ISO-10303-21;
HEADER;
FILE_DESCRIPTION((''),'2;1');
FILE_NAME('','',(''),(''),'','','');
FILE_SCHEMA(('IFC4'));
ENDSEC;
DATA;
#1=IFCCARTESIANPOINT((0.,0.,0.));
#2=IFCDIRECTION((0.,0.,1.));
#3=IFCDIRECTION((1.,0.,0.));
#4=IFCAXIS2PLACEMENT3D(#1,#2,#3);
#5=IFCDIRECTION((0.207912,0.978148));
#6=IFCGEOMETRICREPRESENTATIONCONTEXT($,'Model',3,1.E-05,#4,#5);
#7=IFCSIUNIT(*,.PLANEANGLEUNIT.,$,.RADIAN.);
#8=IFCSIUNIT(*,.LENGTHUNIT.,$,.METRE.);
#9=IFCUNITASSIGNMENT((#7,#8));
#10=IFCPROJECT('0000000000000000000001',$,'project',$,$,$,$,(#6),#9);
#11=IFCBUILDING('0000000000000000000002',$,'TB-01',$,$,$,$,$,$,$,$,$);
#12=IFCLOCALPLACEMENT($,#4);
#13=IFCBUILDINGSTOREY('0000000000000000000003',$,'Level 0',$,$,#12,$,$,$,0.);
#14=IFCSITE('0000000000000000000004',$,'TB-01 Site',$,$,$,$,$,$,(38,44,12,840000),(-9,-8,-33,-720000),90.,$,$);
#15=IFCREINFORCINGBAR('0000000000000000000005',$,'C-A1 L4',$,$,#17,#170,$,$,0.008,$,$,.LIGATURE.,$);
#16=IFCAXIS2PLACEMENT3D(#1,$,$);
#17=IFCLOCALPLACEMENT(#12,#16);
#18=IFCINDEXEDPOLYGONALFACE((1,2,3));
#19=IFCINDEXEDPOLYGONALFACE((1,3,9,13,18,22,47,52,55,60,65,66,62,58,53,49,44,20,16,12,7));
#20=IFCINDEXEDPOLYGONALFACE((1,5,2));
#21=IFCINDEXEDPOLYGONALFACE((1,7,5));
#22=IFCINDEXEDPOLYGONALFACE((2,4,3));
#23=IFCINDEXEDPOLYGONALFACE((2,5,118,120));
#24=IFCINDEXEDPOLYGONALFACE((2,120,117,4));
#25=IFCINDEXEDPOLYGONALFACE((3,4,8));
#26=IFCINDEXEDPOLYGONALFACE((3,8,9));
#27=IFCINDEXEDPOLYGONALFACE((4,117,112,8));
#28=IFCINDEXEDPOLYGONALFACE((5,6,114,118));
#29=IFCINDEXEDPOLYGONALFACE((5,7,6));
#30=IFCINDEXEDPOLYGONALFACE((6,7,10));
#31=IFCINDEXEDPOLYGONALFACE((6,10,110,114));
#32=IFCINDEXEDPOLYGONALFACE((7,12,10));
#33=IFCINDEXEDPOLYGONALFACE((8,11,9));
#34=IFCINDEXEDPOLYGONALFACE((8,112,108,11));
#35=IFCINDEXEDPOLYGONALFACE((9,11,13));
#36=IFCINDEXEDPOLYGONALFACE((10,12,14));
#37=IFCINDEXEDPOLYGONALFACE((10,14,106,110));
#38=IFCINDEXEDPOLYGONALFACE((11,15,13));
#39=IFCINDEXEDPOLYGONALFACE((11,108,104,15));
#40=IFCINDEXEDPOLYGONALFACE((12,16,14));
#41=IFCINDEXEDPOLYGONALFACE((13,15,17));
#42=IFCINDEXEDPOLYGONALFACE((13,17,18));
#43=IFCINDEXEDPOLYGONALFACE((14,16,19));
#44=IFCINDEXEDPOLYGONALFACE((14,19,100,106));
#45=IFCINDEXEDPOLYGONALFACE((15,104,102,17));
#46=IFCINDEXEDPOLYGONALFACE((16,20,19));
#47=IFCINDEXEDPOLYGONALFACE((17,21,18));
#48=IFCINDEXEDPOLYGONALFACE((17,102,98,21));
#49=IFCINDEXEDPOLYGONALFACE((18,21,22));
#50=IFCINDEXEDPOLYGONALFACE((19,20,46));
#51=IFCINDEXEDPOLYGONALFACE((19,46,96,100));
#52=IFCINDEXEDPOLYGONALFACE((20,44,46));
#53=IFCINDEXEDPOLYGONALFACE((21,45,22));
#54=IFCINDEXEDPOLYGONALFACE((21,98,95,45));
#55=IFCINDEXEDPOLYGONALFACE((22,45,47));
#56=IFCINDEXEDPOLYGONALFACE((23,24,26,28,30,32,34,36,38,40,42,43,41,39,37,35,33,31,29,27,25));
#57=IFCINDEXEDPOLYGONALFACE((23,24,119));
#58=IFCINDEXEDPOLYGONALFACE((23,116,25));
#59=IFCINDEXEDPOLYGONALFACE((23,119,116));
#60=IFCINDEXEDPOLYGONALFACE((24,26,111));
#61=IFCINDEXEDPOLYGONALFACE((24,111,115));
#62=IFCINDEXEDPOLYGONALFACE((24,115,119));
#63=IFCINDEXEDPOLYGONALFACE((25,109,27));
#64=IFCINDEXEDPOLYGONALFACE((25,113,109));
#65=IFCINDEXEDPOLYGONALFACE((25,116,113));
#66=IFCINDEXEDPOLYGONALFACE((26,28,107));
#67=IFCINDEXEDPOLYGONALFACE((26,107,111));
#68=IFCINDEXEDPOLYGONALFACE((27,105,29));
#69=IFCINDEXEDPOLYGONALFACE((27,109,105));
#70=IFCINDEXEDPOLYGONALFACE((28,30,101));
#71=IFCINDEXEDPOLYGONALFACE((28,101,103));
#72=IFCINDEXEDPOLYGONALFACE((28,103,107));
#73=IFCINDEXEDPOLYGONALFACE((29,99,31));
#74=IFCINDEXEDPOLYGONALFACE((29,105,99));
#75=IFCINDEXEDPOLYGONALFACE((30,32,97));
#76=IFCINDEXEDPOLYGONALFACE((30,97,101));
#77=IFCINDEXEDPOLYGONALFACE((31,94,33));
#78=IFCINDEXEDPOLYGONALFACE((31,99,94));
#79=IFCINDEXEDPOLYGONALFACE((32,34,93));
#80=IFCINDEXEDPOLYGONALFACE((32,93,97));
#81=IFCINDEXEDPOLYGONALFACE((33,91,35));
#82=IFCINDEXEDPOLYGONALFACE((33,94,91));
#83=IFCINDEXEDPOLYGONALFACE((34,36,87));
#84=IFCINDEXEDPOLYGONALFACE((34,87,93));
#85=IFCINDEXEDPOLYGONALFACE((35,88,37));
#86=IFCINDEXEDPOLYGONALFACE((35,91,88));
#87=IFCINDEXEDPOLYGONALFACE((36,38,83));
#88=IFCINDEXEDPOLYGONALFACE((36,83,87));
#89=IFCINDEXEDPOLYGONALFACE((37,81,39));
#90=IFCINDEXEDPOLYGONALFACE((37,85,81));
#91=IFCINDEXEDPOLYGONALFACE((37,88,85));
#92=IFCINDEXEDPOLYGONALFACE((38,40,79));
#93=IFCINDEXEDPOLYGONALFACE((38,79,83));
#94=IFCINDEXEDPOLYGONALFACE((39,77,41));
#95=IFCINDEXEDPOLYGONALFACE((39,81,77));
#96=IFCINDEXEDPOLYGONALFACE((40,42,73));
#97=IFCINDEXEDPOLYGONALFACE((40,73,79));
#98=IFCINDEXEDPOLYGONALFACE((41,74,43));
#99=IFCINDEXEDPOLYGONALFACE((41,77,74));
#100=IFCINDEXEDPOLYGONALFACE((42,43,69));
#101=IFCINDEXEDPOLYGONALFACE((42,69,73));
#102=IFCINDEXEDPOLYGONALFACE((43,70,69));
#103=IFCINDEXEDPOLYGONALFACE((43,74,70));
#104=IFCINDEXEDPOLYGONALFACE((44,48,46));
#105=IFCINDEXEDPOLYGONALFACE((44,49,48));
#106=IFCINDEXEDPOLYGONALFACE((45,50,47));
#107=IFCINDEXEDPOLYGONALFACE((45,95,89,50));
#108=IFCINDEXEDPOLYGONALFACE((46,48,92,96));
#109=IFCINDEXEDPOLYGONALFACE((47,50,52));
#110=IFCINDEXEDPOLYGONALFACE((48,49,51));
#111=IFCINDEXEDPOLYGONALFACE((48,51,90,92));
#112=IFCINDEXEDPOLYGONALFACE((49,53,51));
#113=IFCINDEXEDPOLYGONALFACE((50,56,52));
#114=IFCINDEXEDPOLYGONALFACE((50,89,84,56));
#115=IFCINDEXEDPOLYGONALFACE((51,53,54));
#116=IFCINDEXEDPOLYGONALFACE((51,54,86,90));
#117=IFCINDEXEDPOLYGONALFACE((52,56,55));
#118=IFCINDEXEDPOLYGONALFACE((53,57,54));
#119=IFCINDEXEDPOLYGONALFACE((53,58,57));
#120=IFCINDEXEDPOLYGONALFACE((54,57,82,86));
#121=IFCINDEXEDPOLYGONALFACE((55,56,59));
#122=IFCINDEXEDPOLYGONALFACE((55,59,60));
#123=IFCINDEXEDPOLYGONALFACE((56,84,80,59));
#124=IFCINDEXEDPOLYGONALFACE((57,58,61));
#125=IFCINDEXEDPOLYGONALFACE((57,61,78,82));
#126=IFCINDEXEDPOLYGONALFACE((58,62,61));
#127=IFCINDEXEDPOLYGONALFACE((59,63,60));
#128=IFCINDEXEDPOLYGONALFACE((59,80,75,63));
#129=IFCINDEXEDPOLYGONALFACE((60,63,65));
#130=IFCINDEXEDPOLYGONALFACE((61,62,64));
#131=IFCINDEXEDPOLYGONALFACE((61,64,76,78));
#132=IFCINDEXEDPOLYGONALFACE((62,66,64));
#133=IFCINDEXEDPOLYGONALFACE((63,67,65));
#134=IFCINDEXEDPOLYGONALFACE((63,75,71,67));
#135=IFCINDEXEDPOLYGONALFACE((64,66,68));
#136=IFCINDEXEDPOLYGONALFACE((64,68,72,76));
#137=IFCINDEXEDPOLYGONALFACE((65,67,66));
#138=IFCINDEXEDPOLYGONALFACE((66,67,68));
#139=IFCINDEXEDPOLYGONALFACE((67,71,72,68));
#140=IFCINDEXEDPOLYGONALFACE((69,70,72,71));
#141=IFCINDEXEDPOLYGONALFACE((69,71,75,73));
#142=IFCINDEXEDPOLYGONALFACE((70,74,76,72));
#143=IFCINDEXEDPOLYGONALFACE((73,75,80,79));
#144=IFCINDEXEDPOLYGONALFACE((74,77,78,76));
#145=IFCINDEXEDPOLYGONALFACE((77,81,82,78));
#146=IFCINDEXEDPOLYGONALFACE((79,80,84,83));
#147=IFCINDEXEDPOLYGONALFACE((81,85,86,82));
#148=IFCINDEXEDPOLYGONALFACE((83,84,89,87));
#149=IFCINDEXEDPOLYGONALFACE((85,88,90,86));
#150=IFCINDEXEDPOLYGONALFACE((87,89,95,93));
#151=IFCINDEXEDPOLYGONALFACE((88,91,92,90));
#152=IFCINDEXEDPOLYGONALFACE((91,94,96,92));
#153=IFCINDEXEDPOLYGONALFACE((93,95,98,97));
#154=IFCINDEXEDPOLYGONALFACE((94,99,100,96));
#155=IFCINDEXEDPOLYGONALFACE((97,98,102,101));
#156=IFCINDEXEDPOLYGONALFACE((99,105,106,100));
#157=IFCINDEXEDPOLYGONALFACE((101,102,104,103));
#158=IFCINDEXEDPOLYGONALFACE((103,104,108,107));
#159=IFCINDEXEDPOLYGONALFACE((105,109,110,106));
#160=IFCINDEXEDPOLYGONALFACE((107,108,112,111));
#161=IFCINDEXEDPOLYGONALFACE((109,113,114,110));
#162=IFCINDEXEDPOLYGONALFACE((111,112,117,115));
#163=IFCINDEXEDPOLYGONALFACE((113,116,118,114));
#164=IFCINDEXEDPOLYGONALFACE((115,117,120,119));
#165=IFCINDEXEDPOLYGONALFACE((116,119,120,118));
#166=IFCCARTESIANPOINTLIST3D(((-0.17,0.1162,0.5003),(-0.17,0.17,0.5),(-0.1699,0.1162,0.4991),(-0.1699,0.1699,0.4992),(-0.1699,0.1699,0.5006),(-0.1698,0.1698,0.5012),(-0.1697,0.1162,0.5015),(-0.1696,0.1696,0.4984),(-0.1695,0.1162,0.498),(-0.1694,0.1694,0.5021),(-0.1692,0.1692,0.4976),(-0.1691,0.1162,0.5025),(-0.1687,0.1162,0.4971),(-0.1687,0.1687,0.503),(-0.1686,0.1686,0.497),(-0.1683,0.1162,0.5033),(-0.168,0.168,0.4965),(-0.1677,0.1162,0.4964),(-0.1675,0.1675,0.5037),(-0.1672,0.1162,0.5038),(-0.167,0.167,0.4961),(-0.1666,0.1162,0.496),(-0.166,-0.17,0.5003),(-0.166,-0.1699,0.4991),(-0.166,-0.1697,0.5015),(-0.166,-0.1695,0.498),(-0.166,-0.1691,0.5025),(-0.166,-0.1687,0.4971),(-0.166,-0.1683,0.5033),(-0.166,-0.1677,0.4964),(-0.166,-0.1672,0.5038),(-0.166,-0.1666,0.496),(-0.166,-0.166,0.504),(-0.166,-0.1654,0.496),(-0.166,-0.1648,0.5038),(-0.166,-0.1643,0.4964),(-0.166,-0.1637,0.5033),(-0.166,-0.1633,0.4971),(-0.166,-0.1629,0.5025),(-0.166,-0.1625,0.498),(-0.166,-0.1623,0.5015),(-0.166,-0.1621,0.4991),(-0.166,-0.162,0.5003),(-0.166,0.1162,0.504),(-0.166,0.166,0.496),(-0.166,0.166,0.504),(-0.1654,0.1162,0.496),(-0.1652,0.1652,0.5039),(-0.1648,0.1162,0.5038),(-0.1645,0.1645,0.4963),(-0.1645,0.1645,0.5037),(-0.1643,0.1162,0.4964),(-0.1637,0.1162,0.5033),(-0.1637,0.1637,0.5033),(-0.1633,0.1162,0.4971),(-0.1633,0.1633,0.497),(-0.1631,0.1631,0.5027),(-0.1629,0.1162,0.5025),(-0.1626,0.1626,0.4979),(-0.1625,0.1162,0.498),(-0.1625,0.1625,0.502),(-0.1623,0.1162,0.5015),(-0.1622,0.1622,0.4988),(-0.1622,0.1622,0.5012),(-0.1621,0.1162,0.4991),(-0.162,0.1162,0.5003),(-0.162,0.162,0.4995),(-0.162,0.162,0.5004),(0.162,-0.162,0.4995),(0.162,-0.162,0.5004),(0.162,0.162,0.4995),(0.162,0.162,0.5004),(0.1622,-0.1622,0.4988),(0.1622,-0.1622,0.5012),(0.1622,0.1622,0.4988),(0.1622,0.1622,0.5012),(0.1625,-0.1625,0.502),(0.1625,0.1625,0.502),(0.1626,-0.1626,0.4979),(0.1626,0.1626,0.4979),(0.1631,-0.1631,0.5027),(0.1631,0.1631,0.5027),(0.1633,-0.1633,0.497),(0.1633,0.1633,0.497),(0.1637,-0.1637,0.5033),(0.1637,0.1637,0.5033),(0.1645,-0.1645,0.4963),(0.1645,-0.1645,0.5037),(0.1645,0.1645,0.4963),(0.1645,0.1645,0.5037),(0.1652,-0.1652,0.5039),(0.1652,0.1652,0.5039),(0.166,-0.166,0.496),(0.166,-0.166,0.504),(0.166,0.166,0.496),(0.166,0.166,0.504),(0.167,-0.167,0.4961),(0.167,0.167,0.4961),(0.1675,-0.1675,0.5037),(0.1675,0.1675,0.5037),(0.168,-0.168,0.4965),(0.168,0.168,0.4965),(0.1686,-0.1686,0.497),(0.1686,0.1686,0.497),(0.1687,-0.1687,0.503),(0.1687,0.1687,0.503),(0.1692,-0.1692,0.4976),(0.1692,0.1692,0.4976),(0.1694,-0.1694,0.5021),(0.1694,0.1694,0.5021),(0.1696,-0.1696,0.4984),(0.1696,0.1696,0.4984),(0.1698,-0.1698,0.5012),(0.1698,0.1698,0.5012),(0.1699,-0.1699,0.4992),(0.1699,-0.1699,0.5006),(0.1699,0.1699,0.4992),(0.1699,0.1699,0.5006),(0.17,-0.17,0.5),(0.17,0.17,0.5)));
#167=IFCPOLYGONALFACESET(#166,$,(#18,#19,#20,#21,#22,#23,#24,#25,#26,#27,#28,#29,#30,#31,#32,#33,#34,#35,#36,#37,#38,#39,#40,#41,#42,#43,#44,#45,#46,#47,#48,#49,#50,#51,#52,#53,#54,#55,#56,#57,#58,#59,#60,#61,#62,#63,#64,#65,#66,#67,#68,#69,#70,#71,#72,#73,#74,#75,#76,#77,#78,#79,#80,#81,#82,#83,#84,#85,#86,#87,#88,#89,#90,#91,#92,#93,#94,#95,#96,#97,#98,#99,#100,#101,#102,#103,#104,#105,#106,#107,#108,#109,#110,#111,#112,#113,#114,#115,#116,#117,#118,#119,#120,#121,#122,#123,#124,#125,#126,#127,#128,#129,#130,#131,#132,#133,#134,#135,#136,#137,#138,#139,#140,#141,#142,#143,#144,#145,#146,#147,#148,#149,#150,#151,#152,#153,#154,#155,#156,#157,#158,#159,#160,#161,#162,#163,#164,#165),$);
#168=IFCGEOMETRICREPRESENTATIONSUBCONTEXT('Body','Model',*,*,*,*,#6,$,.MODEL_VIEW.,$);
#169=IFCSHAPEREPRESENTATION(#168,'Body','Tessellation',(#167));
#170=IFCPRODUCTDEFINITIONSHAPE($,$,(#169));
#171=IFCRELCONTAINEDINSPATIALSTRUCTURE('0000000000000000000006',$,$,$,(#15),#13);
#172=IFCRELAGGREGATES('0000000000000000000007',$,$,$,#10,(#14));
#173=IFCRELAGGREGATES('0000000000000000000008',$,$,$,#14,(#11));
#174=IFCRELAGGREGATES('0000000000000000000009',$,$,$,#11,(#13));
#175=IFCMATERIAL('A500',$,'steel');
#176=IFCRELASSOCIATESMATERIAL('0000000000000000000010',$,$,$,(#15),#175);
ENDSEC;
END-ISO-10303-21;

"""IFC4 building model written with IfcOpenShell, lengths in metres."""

from ifc_helpers import new_model, entity, si_unit, direction, origin_with_axes, place, context, subcontext, project, spatial, material, element, save


model = new_model("IFC4")

# Units and contexts
model_context = context("Model", 3, precision=1e-05, world=origin_with_axes(), true_north=direction((0.207912, 0.978148)))
body_context = subcontext(model_context, "Body", "Model", "MODEL_VIEW")
ifc_project = project(units=[si_unit("PLANEANGLEUNIT", "RADIAN"), si_unit("LENGTHUNIT", "METRE")], contexts=[model_context])

# Site, building, storey
site = spatial("IfcSite", under=ifc_project, Name="TB-01 Site", RefLatitude=(38, 44, 12, 840000), RefLongitude=(-9, -8, -33, -720000), RefElevation=90.0)
building = spatial("IfcBuilding", under=site, Name="TB-01")
storey_placement = place(None, origin_with_axes())
storey = spatial("IfcBuildingStorey", under=building, at=storey_placement, Name="Level 0", Elevation=0.0)

# Reinforcing bar
ifc_material_1 = material(Name="A500", Category="steel")
reinforcing_bar_1_placement = place(storey_placement, origin_with_axes())
element("IfcReinforcingBar", 1, at=reinforcing_bar_1_placement, inside=storey, material=ifc_material_1, Name="C-A1 L4", NominalDiameter=0.008, PredefinedType="LIGATURE", context=body_context, shape_type="AdvancedSweptSolid", body=[
    entity("IfcSweptDiskSolid", entity("IfcPolyline", [entity("IfcCartesianPoint", [-0.166, -0.166, 0.5]), entity("IfcCartesianPoint", [0.166, -0.166, 0.5]), entity("IfcCartesianPoint", [0.166, 0.166, 0.5]), entity("IfcCartesianPoint", [-0.166, 0.166, 0.5]), entity("IfcCartesianPoint", [-0.166, 0.1162, 0.5])]), 0.004),
])

save(model, "model.ifc")
